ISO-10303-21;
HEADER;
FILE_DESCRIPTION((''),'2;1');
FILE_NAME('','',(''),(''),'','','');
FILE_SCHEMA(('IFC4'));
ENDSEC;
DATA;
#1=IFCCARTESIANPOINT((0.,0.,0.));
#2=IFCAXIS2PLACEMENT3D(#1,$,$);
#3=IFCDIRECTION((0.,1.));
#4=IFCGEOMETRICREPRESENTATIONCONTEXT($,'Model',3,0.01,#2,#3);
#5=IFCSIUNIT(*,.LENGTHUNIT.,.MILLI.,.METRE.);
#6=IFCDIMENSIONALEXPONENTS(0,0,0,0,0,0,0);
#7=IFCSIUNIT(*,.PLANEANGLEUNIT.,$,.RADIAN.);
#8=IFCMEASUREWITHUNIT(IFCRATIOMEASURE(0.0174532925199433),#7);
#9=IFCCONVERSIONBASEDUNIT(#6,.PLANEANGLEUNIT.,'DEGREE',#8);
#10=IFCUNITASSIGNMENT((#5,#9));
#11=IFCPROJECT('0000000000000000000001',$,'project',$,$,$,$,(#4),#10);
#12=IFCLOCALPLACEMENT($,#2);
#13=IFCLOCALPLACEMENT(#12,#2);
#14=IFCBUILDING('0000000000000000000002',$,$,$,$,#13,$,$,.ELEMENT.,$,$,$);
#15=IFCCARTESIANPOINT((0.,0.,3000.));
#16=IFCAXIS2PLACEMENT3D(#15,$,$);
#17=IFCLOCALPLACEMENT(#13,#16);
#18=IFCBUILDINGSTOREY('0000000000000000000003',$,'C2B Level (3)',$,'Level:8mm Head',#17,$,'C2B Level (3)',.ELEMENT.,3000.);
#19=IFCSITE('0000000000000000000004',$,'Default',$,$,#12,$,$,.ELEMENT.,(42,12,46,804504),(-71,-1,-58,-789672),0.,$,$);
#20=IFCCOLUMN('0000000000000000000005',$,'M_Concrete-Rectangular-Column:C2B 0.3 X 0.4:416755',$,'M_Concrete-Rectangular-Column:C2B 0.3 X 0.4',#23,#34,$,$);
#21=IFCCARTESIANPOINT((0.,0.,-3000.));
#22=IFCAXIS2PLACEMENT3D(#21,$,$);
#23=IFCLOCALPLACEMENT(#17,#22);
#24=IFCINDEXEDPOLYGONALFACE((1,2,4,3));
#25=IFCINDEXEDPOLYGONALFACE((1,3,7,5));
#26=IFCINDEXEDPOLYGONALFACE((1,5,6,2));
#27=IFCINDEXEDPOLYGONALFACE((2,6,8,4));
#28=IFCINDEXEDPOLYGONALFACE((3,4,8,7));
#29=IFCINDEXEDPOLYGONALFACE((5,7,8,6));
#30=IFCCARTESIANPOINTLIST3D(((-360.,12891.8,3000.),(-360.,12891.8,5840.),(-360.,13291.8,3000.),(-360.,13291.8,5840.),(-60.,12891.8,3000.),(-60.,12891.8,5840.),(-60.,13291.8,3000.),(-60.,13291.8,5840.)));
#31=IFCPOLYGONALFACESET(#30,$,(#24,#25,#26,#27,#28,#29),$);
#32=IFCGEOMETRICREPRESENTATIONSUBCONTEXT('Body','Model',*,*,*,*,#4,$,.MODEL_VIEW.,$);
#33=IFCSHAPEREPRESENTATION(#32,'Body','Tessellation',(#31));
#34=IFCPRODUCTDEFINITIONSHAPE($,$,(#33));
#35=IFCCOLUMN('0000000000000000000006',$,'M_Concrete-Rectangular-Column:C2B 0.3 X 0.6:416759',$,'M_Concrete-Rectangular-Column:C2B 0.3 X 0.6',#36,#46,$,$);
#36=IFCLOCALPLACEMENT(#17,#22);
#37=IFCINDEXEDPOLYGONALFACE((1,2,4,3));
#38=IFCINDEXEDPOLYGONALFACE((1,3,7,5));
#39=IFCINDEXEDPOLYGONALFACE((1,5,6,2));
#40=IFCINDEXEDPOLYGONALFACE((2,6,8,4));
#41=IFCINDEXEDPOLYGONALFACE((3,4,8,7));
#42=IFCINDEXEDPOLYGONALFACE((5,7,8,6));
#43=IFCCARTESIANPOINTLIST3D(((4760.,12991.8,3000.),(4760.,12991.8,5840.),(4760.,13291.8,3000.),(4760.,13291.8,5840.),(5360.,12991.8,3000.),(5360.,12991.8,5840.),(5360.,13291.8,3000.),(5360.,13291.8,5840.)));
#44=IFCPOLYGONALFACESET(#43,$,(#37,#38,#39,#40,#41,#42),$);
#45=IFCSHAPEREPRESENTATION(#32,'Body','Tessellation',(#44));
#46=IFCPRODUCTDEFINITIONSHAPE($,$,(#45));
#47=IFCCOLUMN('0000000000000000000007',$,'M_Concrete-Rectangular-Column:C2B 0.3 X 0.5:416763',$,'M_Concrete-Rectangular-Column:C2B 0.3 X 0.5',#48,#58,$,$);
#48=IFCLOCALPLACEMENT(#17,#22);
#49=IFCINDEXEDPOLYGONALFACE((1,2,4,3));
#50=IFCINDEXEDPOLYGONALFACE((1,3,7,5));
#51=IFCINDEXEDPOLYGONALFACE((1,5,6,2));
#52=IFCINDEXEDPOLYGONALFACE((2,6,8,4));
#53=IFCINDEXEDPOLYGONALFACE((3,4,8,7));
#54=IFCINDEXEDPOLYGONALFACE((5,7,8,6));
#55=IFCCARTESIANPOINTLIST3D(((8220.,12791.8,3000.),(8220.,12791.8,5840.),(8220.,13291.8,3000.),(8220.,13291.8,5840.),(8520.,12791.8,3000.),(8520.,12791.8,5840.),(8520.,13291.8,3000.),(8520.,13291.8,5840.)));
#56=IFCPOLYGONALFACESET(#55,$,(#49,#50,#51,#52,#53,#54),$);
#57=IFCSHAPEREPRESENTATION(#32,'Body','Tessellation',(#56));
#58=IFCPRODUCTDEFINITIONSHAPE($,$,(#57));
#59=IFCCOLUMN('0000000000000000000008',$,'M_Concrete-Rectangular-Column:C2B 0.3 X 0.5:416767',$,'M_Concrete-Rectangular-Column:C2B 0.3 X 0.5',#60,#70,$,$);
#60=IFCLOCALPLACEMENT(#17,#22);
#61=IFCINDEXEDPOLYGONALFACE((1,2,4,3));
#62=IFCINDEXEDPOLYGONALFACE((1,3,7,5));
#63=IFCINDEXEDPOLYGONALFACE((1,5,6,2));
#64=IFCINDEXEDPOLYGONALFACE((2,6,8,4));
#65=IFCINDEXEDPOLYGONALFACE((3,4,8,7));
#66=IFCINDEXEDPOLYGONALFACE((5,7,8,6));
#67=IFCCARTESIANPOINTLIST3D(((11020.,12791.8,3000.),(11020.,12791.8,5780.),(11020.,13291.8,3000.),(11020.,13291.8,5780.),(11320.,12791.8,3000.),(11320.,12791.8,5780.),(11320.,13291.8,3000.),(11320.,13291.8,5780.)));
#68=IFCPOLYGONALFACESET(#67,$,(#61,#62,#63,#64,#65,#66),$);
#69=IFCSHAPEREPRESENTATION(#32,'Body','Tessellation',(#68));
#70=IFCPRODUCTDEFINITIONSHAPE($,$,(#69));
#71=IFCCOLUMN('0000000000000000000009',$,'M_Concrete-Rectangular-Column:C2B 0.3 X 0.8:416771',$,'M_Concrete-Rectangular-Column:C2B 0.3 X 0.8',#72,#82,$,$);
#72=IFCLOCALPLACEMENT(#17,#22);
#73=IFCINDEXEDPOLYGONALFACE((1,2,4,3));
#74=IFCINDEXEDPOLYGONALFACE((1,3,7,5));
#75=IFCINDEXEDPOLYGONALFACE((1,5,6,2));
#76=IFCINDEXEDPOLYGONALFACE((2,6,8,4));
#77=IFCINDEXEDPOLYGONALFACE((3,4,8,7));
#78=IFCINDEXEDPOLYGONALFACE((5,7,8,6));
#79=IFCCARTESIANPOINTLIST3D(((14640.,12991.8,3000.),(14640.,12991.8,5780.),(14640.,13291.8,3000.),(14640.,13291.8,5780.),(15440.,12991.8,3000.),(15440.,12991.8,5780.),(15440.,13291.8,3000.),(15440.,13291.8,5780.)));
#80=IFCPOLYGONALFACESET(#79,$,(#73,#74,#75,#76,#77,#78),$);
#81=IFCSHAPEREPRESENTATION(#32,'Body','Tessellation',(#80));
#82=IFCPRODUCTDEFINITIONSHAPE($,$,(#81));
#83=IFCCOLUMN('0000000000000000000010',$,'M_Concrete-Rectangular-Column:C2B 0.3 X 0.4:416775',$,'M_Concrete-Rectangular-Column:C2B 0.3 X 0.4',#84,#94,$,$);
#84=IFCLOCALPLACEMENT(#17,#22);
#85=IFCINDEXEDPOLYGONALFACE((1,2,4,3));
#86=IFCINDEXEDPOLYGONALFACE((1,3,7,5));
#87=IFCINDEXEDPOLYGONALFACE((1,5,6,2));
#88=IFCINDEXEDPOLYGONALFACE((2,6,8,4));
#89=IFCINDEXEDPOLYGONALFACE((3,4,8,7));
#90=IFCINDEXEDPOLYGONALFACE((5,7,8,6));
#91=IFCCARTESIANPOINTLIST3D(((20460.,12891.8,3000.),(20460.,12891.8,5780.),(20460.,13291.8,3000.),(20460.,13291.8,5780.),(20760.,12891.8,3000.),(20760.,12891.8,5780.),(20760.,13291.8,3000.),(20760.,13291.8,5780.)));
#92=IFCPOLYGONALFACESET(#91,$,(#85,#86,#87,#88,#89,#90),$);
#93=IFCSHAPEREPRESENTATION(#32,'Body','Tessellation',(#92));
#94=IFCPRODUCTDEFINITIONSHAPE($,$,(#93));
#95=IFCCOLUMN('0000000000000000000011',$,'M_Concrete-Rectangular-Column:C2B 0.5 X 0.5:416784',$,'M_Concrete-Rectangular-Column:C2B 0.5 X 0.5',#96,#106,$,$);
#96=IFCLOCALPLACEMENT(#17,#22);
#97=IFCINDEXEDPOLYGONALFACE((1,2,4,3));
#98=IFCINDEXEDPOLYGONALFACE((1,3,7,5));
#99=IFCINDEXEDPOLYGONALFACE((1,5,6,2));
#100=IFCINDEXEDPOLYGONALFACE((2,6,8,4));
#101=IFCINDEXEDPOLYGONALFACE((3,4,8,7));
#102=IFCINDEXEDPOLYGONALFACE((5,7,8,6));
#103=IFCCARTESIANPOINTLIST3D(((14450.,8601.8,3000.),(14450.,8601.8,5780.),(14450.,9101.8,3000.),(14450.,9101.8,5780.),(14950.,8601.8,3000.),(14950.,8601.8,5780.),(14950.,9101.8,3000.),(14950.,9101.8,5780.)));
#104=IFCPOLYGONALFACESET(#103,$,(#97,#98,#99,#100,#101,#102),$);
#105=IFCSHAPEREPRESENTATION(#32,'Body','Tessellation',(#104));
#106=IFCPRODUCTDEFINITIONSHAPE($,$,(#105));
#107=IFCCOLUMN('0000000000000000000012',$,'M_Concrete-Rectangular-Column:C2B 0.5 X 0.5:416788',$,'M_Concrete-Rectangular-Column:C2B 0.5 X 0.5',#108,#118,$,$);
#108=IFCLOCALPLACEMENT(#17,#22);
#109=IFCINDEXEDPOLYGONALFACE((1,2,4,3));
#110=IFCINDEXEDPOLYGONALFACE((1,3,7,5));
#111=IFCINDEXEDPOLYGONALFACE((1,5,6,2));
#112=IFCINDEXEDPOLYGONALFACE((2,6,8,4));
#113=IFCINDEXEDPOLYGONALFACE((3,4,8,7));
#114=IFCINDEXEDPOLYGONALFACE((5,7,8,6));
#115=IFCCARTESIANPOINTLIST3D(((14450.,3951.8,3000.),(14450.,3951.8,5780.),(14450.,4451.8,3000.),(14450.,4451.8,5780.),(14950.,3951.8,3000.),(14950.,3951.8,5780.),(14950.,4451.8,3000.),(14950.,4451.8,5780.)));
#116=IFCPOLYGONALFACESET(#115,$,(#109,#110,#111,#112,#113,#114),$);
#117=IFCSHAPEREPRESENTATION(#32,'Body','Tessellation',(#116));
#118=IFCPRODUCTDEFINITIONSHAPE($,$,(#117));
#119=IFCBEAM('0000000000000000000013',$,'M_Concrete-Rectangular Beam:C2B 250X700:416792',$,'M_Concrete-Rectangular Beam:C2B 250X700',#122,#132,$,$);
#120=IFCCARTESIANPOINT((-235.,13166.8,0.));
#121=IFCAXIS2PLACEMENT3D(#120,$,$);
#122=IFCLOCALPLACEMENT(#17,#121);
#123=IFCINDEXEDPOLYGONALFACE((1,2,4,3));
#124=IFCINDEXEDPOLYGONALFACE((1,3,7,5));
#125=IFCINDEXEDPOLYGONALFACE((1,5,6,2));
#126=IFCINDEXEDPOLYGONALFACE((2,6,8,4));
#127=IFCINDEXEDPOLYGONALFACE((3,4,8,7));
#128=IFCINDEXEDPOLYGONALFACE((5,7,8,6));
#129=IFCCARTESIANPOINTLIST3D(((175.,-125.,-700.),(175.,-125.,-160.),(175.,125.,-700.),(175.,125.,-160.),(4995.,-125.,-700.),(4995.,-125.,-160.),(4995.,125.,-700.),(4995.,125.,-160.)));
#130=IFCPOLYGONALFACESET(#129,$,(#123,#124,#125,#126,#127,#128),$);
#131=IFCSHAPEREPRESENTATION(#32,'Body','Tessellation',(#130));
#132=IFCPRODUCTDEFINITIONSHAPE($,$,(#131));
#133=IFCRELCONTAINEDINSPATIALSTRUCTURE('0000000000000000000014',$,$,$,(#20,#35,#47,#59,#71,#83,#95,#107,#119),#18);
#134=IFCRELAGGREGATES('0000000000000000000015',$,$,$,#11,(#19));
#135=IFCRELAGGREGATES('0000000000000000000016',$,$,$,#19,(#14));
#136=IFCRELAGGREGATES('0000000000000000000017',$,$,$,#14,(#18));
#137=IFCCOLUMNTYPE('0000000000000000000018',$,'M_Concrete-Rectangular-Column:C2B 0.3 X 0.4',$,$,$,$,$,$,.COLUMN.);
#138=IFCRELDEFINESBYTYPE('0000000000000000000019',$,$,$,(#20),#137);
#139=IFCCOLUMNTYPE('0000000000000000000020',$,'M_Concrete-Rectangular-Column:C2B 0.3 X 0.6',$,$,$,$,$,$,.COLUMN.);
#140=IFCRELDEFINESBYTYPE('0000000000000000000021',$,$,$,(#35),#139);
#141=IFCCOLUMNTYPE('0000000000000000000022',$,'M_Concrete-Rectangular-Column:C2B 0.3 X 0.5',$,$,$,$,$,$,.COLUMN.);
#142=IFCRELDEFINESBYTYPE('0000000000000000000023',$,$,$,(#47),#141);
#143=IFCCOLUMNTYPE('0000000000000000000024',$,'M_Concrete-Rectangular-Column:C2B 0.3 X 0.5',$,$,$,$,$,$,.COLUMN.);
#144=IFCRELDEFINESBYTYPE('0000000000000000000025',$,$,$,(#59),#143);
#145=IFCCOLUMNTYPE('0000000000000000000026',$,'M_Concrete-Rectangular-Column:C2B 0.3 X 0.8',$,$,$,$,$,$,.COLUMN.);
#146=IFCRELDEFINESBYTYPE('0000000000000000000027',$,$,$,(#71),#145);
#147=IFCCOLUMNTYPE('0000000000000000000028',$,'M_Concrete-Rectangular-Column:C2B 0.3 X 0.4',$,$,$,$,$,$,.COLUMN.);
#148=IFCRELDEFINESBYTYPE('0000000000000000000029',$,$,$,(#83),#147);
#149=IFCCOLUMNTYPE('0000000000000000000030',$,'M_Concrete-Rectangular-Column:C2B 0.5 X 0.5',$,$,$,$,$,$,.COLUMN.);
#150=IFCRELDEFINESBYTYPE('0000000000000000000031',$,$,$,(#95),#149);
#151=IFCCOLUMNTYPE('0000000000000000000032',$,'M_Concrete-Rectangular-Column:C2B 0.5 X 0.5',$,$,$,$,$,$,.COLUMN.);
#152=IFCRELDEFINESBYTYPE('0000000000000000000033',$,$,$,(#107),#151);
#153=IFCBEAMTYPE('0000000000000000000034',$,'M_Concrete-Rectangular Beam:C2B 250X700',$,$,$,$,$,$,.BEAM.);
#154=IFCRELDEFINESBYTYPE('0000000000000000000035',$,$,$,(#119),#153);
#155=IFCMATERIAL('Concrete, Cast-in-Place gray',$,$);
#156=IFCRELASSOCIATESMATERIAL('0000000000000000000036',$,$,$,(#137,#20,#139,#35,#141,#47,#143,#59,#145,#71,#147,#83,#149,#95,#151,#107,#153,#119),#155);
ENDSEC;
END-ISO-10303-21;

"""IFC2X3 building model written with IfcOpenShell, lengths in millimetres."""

from ifc_helpers import new_model, entity, si_unit, converted_unit, direction, frame, frame_2d, origin, origin_2d_with_axis, place, context, subcontext, project, spatial, rectangle, extrude, source, transform, mapped, material, type_object, type_shapes, element, save


model = new_model("IFC2X3")

# Units and contexts
model_context = context("Model", 3, precision=0.01, world=origin(), true_north=direction((0.0, 1.0)))
body_context = subcontext(model_context, "Body", "Model", "MODEL_VIEW")
ifc_project = project(units=[si_unit("LENGTHUNIT", "METRE", prefix="MILLI"), converted_unit("PLANEANGLEUNIT", "DEGREE", entity("IfcRatioMeasure", 0.0174532925199433), si_unit("PLANEANGLEUNIT", "RADIAN"), dimensions=[0, 0, 0, 0, 0, 0, 0])], contexts=[model_context])

# Site, building, storey
site_placement = place(None, origin())
site = spatial("IfcSite", under=ifc_project, at=site_placement, Name="Default", CompositionType="ELEMENT", RefLatitude=(42, 12, 46, 804504), RefLongitude=(-71, -1, -58, -789672), RefElevation=0.0)
building_placement = place(site_placement, origin())
building = spatial("IfcBuilding", under=site, at=building_placement, CompositionType="ELEMENT")
storey_placement = place(building_placement, frame((0.0, 0.0, 3000.0)))
storey = spatial("IfcBuildingStorey", under=building, at=storey_placement, Name="C2B Level (3)", ObjectType="Level:8mm Head", LongName="C2B Level (3)", CompositionType="ELEMENT", Elevation=3000.0)

# Columns
ifc_material = material(Name="Concrete, Cast-in-Place gray")
column_type_1 = type_object("IfcColumnType", Name="M_Concrete-Rectangular-Column:C2B 0.3 X 0.4", PredefinedType="COLUMN", material=ifc_material)
shared_shape_1 = source(origin(), body_context, "Body", "SweptSolid", [
    extrude(rectangle(XDim=400.0, YDim=300.0, at=frame_2d((0.0, 0.0), x_axis=(1.0, 0.0))), frame((-210.0, 13091.8, 3000.0), z_axis=(0.0, 0.0, 1.0), x_axis=(0.0, -1.0, 0.0)), (0.0, 0.0, 1.0), 2840.0),
])
type_shapes(column_type_1, [shared_shape_1])
column_1_placement = place(storey_placement, frame((0.0, 0.0, -3000.0)))
element("IfcColumn", 1, at=column_1_placement, inside=storey, type_object=column_type_1, material=ifc_material, Name="M_Concrete-Rectangular-Column:C2B 0.3 X 0.4:416755", ObjectType="M_Concrete-Rectangular-Column:C2B 0.3 X 0.4", context=body_context, shape_type="MappedRepresentation", body=[
    mapped(shared_shape_1, transform((0.0, 0.0, 0.0), scale=1.0)),
])
column_type_2 = type_object("IfcColumnType", Name="M_Concrete-Rectangular-Column:C2B 0.3 X 0.6", PredefinedType="COLUMN", material=ifc_material)
shared_shape_2 = source(origin(), body_context, "Body", "SweptSolid", [
    extrude(rectangle(XDim=300.0, YDim=600.0, at=origin_2d_with_axis()), frame((5060.0, 13141.8, 3000.0), z_axis=(0.0, 0.0, 1.0), x_axis=(0.0, -1.0, 0.0)), (0.0, 0.0, 1.0), 2840.0),
])
type_shapes(column_type_2, [shared_shape_2])
column_2_placement = place(storey_placement, frame((0.0, 0.0, -3000.0)))
element("IfcColumn", 2, at=column_2_placement, inside=storey, type_object=column_type_2, material=ifc_material, Name="M_Concrete-Rectangular-Column:C2B 0.3 X 0.6:416759", ObjectType="M_Concrete-Rectangular-Column:C2B 0.3 X 0.6", context=body_context, shape_type="MappedRepresentation", body=[
    mapped(shared_shape_2, transform((0.0, 0.0, 0.0), scale=1.0)),
])
column_type_3 = type_object("IfcColumnType", Name="M_Concrete-Rectangular-Column:C2B 0.3 X 0.5", PredefinedType="COLUMN", material=ifc_material)
shared_shape_3 = source(origin(), body_context, "Body", "SweptSolid", [
    extrude(rectangle(XDim=500.0, YDim=300.0, at=frame_2d((0.0, 0.0), x_axis=(1.0, 0.0))), frame((8370.0, 13041.8, 3000.0), z_axis=(0.0, 0.0, 1.0), x_axis=(0.0, -1.0, 0.0)), (0.0, 0.0, 1.0), 2840.0),
])
type_shapes(column_type_3, [shared_shape_3])
column_3_placement = place(storey_placement, frame((0.0, 0.0, -3000.0)))
element("IfcColumn", 3, at=column_3_placement, inside=storey, type_object=column_type_3, material=ifc_material, Name="M_Concrete-Rectangular-Column:C2B 0.3 X 0.5:416763", ObjectType="M_Concrete-Rectangular-Column:C2B 0.3 X 0.5", context=body_context, shape_type="MappedRepresentation", body=[
    mapped(shared_shape_3, transform((0.0, 0.0, 0.0), scale=1.0)),
])
column_type_4 = type_object("IfcColumnType", Name="M_Concrete-Rectangular-Column:C2B 0.3 X 0.5", PredefinedType="COLUMN", material=ifc_material)
shared_shape_4 = source(origin(), body_context, "Body", "SweptSolid", [
    extrude(rectangle(XDim=500.0, YDim=300.0, at=origin_2d_with_axis()), frame((11170.0, 13041.8, 3000.0), z_axis=(0.0, 0.0, 1.0), x_axis=(0.0, -1.0, 0.0)), (0.0, 0.0, 1.0), 2780.0),
])
type_shapes(column_type_4, [shared_shape_4])
column_4_placement = place(storey_placement, frame((0.0, 0.0, -3000.0)))
element("IfcColumn", 4, at=column_4_placement, inside=storey, type_object=column_type_4, material=ifc_material, Name="M_Concrete-Rectangular-Column:C2B 0.3 X 0.5:416767", ObjectType="M_Concrete-Rectangular-Column:C2B 0.3 X 0.5", context=body_context, shape_type="MappedRepresentation", body=[
    mapped(shared_shape_4, transform((0.0, 0.0, 0.0), scale=1.0)),
])
column_type_5 = type_object("IfcColumnType", Name="M_Concrete-Rectangular-Column:C2B 0.3 X 0.8", PredefinedType="COLUMN", material=ifc_material)
shared_shape_5 = source(origin(), body_context, "Body", "SweptSolid", [
    extrude(rectangle(XDim=300.0, YDim=800.0, at=origin_2d_with_axis()), frame((15040.0, 13141.8, 3000.0), z_axis=(0.0, 0.0, 1.0), x_axis=(0.0, -1.0, 0.0)), (0.0, 0.0, 1.0), 2780.0),
])
type_shapes(column_type_5, [shared_shape_5])
column_5_placement = place(storey_placement, frame((0.0, 0.0, -3000.0)))
element("IfcColumn", 5, at=column_5_placement, inside=storey, type_object=column_type_5, material=ifc_material, Name="M_Concrete-Rectangular-Column:C2B 0.3 X 0.8:416771", ObjectType="M_Concrete-Rectangular-Column:C2B 0.3 X 0.8", context=body_context, shape_type="MappedRepresentation", body=[
    mapped(shared_shape_5, transform((0.0, 0.0, 0.0), scale=1.0)),
])
column_type_6 = type_object("IfcColumnType", Name="M_Concrete-Rectangular-Column:C2B 0.3 X 0.4", PredefinedType="COLUMN", material=ifc_material)
shared_shape_6 = source(origin(), body_context, "Body", "SweptSolid", [
    extrude(rectangle(XDim=400.0, YDim=300.0, at=origin_2d_with_axis()), frame((20610.0, 13091.8, 3000.0), z_axis=(0.0, 0.0, 1.0), x_axis=(0.0, -1.0, 0.0)), (0.0, 0.0, 1.0), 2780.0),
])
type_shapes(column_type_6, [shared_shape_6])
column_6_placement = place(storey_placement, frame((0.0, 0.0, -3000.0)))
element("IfcColumn", 6, at=column_6_placement, inside=storey, type_object=column_type_6, material=ifc_material, Name="M_Concrete-Rectangular-Column:C2B 0.3 X 0.4:416775", ObjectType="M_Concrete-Rectangular-Column:C2B 0.3 X 0.4", context=body_context, shape_type="MappedRepresentation", body=[
    mapped(shared_shape_6, transform((0.0, 0.0, 0.0), scale=1.0)),
])
column_type_7 = type_object("IfcColumnType", Name="M_Concrete-Rectangular-Column:C2B 0.5 X 0.5", PredefinedType="COLUMN", material=ifc_material)
shared_shape_7 = source(origin(), body_context, "Body", "SweptSolid", [
    extrude(rectangle(XDim=500.0, YDim=500.0, at=frame_2d((0.0, 0.0), x_axis=(1.0, 0.0))), frame((14700.0, 8851.8, 3000.0), z_axis=(0.0, 0.0, 1.0), x_axis=(0.0, -1.0, 0.0)), (0.0, 0.0, 1.0), 2780.0),
])
type_shapes(column_type_7, [shared_shape_7])
column_7_placement = place(storey_placement, frame((0.0, 0.0, -3000.0)))
element("IfcColumn", 7, at=column_7_placement, inside=storey, type_object=column_type_7, material=ifc_material, Name="M_Concrete-Rectangular-Column:C2B 0.5 X 0.5:416784", ObjectType="M_Concrete-Rectangular-Column:C2B 0.5 X 0.5", context=body_context, shape_type="MappedRepresentation", body=[
    mapped(shared_shape_7, transform((0.0, 0.0, 0.0), scale=1.0)),
])
column_type_8 = type_object("IfcColumnType", Name="M_Concrete-Rectangular-Column:C2B 0.5 X 0.5", PredefinedType="COLUMN", material=ifc_material)
shared_shape_8 = source(origin(), body_context, "Body", "SweptSolid", [
    extrude(rectangle(XDim=500.0, YDim=500.0, at=frame_2d((0.0, 0.0), x_axis=(1.0, 0.0))), frame((14700.0, 4201.8, 3000.0), z_axis=(0.0, 0.0, 1.0), x_axis=(0.0, -1.0, 0.0)), (0.0, 0.0, 1.0), 2780.0),
])
type_shapes(column_type_8, [shared_shape_8])
column_8_placement = place(storey_placement, frame((0.0, 0.0, -3000.0)))
element("IfcColumn", 8, at=column_8_placement, inside=storey, type_object=column_type_8, material=ifc_material, Name="M_Concrete-Rectangular-Column:C2B 0.5 X 0.5:416788", ObjectType="M_Concrete-Rectangular-Column:C2B 0.5 X 0.5", context=body_context, shape_type="MappedRepresentation", body=[
    mapped(shared_shape_8, transform((0.0, 0.0, 0.0), scale=1.0)),
])

# Beam
beam_type_1 = type_object("IfcBeamType", Name="M_Concrete-Rectangular Beam:C2B 250X700", PredefinedType="BEAM", material=ifc_material)
beam_1_placement = place(storey_placement, frame((-235.0, 13166.8, 0.0)))
element("IfcBeam", 9, at=beam_1_placement, inside=storey, type_object=beam_type_1, material=ifc_material, Name="M_Concrete-Rectangular Beam:C2B 250X700:416792", ObjectType="M_Concrete-Rectangular Beam:C2B 250X700", context=body_context, shape_type="SweptSolid", body=[
    extrude(rectangle(XDim=540.0, YDim=250.0, at=origin_2d_with_axis()), frame((175.0, 0.0, -430.0), z_axis=(1.0, 0.0, 0.0), x_axis=(0.0, 0.0, -1.0)), (0.0, 0.0, 1.0), 4820.0),
])

save(model, "model.ifc")
